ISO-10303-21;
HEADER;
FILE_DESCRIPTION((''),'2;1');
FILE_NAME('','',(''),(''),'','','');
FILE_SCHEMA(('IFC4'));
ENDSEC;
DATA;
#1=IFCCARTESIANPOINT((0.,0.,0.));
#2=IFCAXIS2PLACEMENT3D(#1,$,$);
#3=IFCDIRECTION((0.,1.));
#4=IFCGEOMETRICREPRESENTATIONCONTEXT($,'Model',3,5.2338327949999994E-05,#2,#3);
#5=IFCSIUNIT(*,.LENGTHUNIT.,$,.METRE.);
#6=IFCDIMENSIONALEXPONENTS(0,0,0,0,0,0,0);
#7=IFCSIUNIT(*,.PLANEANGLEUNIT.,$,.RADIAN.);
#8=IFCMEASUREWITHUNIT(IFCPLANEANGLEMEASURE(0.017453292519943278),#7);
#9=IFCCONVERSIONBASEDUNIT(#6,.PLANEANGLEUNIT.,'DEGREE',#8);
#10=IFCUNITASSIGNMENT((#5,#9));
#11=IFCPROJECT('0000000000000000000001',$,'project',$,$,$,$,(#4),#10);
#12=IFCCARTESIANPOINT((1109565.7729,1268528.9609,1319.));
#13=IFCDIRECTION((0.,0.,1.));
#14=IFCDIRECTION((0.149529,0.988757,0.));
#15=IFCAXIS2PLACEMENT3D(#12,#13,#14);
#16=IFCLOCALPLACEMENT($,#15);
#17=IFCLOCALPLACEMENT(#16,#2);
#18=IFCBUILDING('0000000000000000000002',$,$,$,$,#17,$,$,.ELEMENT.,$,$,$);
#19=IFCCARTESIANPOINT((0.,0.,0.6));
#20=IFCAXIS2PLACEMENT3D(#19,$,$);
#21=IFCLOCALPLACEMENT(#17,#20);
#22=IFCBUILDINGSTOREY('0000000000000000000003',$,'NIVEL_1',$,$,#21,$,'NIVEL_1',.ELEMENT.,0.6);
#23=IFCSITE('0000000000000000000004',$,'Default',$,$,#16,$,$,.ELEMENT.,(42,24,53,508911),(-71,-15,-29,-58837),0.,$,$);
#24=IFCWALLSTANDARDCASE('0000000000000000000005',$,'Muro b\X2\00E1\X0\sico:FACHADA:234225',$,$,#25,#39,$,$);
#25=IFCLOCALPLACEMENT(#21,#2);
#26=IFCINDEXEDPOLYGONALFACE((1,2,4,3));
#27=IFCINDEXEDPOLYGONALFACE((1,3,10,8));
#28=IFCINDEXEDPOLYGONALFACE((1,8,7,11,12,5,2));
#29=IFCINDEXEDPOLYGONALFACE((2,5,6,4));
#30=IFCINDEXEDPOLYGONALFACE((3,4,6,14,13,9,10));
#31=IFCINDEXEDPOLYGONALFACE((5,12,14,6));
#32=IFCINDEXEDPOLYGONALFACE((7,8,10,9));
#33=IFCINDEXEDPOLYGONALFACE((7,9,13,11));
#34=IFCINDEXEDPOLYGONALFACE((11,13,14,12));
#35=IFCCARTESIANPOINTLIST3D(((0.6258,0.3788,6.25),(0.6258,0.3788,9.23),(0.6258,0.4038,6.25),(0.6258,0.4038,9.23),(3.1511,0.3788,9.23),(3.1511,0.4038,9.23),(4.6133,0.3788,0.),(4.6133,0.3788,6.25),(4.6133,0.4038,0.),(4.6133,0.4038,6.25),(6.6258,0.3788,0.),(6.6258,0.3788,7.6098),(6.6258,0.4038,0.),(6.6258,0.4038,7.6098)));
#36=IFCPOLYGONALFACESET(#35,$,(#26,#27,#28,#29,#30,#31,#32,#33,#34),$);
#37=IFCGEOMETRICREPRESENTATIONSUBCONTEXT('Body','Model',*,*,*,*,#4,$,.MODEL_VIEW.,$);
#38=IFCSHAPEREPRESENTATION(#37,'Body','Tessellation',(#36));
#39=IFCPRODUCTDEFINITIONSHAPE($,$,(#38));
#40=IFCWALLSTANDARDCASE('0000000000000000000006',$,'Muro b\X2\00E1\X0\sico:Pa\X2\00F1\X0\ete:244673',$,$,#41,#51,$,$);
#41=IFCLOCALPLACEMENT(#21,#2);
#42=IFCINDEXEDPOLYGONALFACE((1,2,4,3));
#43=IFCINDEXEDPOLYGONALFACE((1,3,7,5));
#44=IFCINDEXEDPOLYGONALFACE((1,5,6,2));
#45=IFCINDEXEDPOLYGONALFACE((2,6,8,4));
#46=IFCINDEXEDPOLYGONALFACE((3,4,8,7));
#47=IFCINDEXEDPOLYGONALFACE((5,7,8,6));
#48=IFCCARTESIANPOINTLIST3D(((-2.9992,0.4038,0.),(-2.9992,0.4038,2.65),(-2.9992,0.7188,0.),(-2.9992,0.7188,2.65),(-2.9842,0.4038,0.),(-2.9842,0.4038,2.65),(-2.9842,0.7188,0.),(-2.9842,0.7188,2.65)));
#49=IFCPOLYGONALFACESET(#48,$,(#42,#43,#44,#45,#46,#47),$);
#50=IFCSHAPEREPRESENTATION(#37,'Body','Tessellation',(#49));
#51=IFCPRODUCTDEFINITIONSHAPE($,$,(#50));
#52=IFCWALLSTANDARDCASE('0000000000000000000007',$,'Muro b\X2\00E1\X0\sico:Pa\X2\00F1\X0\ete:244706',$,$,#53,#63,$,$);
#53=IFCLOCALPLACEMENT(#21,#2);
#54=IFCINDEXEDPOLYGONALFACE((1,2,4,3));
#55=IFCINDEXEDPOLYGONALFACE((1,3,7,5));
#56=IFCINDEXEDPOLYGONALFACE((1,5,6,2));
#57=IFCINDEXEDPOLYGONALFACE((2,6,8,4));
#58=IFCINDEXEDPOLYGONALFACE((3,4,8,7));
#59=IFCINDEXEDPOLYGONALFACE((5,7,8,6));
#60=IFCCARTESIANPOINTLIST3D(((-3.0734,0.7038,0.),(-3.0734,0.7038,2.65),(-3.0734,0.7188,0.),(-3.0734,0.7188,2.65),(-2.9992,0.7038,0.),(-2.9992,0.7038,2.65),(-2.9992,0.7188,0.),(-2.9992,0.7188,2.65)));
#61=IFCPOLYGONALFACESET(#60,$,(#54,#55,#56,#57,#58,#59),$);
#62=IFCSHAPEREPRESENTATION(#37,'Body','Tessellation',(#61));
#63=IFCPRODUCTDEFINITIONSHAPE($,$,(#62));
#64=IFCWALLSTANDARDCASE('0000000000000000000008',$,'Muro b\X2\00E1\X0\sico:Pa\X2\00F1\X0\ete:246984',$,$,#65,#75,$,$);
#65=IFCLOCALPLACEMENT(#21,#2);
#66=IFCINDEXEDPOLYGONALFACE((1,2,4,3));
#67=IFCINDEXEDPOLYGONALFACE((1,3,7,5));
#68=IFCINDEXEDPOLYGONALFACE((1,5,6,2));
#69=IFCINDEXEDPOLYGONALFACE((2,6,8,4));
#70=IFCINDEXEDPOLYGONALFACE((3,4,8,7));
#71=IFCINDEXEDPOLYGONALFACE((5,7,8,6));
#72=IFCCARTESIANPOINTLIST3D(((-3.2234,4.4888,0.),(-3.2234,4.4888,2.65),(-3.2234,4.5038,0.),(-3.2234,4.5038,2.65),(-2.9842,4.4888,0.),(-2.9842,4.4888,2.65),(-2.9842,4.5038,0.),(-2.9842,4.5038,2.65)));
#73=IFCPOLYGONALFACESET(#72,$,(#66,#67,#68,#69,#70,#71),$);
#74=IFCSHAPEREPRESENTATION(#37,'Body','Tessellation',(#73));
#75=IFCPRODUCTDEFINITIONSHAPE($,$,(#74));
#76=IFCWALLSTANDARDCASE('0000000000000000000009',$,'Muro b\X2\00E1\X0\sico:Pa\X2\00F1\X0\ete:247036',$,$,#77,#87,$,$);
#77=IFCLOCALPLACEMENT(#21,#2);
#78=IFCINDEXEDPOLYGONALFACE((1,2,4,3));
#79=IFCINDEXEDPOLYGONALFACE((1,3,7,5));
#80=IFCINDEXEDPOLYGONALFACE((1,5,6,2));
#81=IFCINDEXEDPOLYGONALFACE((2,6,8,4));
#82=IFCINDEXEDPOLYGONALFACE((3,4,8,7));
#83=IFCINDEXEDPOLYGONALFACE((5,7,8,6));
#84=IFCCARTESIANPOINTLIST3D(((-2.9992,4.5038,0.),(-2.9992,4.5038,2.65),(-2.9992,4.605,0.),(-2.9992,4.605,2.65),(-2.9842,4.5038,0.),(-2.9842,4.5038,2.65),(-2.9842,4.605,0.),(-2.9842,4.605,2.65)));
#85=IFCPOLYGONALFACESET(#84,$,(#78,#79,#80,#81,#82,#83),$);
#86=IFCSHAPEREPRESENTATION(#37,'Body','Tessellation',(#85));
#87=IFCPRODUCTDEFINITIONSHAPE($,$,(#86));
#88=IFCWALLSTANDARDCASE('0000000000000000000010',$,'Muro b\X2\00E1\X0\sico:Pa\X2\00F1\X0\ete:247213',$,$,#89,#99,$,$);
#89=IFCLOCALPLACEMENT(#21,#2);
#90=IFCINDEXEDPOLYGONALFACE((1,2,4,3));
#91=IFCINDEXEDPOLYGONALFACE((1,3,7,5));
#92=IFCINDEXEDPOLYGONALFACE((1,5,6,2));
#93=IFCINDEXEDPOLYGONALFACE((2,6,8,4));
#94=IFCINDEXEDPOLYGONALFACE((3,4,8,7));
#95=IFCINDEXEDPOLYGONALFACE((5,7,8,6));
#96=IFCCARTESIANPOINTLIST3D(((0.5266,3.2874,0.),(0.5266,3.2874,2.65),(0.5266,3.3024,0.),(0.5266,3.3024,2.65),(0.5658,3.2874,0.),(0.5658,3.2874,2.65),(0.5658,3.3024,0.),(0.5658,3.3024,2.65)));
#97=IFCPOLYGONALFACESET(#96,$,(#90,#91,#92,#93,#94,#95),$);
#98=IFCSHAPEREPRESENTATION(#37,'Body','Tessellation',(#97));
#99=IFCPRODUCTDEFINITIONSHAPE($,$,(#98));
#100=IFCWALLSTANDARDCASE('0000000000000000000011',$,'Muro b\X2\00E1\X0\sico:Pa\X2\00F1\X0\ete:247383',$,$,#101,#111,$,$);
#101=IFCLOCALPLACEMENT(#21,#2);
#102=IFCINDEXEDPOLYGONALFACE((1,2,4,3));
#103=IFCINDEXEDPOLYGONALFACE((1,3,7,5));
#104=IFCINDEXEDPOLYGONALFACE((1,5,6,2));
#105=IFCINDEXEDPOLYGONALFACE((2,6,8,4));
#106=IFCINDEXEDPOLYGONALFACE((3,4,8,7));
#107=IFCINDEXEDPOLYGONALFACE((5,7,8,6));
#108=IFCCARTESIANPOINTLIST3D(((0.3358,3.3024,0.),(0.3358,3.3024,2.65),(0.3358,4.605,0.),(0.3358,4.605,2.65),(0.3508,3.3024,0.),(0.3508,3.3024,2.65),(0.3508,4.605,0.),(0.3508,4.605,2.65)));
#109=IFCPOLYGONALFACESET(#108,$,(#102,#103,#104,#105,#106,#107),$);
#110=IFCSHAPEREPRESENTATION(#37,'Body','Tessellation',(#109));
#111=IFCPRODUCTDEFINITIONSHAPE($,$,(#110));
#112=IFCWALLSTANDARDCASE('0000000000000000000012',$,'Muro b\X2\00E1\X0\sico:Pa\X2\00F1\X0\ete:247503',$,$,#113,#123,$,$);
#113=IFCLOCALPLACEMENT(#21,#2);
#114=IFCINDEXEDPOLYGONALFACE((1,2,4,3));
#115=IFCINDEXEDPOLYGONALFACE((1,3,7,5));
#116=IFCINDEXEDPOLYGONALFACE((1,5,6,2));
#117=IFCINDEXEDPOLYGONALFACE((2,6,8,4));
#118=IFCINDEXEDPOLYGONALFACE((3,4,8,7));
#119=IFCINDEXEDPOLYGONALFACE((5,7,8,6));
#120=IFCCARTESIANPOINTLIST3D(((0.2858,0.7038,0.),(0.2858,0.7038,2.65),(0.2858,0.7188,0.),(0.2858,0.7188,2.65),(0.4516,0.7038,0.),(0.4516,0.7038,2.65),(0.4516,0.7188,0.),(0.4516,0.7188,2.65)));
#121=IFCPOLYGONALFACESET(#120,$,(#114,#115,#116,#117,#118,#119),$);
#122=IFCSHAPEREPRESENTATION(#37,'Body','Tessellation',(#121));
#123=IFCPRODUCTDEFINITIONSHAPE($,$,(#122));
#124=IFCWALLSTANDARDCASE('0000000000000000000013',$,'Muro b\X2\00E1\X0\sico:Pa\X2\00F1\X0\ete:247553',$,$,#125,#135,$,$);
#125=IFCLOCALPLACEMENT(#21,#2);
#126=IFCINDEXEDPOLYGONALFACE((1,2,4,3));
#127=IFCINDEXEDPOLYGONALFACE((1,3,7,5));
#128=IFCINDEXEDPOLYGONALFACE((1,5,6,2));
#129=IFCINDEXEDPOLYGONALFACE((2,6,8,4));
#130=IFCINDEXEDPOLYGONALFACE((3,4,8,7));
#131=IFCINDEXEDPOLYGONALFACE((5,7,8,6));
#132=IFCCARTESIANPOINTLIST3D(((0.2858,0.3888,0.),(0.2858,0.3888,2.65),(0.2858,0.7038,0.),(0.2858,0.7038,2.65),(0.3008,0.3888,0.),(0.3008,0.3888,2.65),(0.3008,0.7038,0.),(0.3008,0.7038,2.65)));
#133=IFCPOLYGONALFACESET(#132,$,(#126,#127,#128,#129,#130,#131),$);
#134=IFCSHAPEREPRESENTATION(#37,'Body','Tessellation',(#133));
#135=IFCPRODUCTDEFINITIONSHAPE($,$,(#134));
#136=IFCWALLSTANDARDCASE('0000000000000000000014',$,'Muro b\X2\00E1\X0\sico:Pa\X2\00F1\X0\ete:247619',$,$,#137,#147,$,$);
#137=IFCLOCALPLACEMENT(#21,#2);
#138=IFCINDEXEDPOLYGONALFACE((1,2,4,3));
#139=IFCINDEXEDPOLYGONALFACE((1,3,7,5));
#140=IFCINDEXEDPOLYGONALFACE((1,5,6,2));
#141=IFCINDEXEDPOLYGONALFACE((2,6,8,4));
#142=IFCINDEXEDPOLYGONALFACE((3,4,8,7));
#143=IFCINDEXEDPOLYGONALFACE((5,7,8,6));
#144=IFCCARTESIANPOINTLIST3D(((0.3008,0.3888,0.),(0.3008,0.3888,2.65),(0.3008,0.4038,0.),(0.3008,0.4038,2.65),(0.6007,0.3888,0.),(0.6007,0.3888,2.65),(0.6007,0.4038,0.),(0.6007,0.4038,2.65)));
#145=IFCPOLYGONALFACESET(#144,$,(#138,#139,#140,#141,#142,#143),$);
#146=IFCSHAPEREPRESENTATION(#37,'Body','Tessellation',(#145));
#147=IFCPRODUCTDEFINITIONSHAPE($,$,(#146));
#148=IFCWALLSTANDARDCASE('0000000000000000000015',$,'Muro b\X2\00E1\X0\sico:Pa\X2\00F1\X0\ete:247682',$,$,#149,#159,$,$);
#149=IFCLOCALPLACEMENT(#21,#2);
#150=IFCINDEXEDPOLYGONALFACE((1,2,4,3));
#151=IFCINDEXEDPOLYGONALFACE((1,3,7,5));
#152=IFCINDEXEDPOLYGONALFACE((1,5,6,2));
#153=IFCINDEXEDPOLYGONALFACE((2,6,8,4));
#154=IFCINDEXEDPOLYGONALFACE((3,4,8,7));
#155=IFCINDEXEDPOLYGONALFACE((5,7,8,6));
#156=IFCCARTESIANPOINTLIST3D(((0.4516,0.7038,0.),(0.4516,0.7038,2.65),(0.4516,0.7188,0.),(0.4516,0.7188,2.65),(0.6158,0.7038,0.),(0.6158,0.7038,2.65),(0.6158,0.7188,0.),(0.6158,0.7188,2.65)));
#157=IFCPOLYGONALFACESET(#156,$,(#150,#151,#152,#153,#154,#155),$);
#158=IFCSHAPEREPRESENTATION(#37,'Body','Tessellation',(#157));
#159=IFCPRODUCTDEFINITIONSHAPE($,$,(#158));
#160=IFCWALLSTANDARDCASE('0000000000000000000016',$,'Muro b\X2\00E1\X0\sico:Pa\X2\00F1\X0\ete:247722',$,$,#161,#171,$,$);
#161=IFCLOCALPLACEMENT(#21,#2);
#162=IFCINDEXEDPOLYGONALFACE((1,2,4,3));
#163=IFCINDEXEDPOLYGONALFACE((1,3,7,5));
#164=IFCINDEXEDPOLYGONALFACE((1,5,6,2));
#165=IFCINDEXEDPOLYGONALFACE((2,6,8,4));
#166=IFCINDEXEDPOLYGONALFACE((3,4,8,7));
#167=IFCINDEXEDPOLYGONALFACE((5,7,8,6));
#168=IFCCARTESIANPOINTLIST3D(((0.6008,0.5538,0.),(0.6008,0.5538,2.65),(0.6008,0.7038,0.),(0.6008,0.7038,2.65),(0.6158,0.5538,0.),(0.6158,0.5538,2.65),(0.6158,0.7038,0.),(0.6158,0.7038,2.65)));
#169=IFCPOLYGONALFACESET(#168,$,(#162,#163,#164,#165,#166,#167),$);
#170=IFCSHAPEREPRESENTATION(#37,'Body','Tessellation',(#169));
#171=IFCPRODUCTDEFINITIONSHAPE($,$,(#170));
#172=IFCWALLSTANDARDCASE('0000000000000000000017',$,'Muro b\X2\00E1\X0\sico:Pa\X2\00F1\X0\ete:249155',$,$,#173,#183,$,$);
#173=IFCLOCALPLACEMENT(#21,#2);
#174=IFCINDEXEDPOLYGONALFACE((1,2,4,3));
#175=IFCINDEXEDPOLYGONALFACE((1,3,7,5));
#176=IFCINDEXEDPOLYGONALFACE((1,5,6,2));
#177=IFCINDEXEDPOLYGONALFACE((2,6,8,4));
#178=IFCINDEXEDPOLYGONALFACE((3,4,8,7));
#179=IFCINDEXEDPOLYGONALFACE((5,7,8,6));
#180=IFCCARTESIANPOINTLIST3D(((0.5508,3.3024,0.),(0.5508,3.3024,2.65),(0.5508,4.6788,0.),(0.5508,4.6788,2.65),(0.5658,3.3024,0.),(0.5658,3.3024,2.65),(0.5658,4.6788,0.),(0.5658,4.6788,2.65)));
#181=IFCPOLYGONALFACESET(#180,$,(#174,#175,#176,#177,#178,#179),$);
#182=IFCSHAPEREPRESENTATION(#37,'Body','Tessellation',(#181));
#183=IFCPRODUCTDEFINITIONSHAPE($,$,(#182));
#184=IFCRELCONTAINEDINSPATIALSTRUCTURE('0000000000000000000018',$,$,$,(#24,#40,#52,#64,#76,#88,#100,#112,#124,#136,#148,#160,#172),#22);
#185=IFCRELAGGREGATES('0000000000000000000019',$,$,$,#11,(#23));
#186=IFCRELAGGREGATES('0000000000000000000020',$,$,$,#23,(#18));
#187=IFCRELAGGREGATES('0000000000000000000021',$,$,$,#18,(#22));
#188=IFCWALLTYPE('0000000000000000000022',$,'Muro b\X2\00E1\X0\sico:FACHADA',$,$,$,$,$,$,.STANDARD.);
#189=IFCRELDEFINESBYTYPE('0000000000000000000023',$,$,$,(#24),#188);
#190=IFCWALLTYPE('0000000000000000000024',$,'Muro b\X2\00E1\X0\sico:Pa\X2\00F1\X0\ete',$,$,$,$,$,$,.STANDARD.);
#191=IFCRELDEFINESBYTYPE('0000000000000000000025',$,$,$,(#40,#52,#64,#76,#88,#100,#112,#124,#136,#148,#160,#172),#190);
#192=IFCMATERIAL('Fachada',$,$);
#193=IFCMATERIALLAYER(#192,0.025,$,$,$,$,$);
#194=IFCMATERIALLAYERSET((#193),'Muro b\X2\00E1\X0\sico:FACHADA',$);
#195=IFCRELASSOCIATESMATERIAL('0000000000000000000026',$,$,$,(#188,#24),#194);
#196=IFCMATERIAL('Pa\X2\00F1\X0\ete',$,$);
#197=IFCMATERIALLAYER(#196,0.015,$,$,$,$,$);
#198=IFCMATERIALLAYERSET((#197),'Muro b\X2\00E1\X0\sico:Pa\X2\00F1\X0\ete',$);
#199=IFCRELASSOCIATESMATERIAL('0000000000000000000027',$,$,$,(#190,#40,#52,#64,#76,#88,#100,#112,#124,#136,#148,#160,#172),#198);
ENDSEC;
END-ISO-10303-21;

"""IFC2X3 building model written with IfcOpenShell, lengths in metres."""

from ifc_helpers import new_model, entity, si_unit, converted_unit, direction, frame, frame_2d, origin, origin_2d_with_axis, place, context, subcontext, project, spatial, rectangle, extrude, clip, halfspace, material, layer, layer_set, layer_usage, type_object, element, save


model = new_model("IFC2X3")

# Units and contexts
model_context = context("Model", 3, precision=5.2338327949999994e-05, world=origin(), true_north=direction((0.0, 1.0)))
body_context = subcontext(model_context, "Body", "Model", "MODEL_VIEW")
ifc_project = project(units=[si_unit("LENGTHUNIT", "METRE"), converted_unit("PLANEANGLEUNIT", "DEGREE", entity("IfcPlaneAngleMeasure", 0.017453292519943278), si_unit("PLANEANGLEUNIT", "RADIAN"), dimensions=[0, 0, 0, 0, 0, 0, 0])], contexts=[model_context])

# Site, building, storey
site_placement = place(None, frame((1109565.7729, 1268528.9609, 1319.0), z_axis=(0.0, 0.0, 1.0), x_axis=(0.149529, 0.988757, 0.0)))
site = spatial("IfcSite", under=ifc_project, at=site_placement, Name="Default", CompositionType="ELEMENT", RefLatitude=(42, 24, 53, 508911), RefLongitude=(-71, -15, -29, -58837), RefElevation=0.0)
building_placement = place(site_placement, origin())
building = spatial("IfcBuilding", under=site, at=building_placement, CompositionType="ELEMENT")
storey_placement = place(building_placement, frame((0.0, 0.0, 0.6)))
storey = spatial("IfcBuildingStorey", under=building, at=storey_placement, Name="NIVEL_1", LongName="NIVEL_1", CompositionType="ELEMENT", Elevation=0.6)

# Shared definitions
ifc_material_1 = material(Name="Pañete")

# Wall, opening
ifc_material_2 = material(Name="Fachada")
ifc_layer_1 = layer(ifc_material_2, 0.025)
ifc_layer_set_1 = layer_set([ifc_layer_1], Name="Muro básico:FACHADA")
ifc_layer_usage_1 = layer_usage(ifc_layer_set_1, "AXIS2", "POSITIVE", -0.0125)
wall_type_1 = type_object("IfcWallType", Name="Muro básico:FACHADA", PredefinedType="STANDARD", material=ifc_layer_set_1)
wall_1_placement = place(storey_placement, frame((0.6258, 0.3913, 0.0)))
wall_1 = element("IfcWallStandardCase", 1, at=wall_1_placement, inside=storey, type_object=wall_type_1, material=ifc_layer_usage_1, Name="Muro básico:FACHADA:234225", context=body_context, shape_type="Clipping", body=[
    clip(extrude(rectangle(XDim=6.0, YDim=0.025, at=frame_2d((3.0, 0.0), x_axis=(-1.0, 0.0))), origin(), (0.0, 0.0, 1.0), 9.23), halfspace(frame((2.5254, -0.0125, 9.23), z_axis=(0.422613, 0.0, 0.90631), x_axis=(0.0, 1.0, 0.0)), False)),
])
opening_1_placement = place(wall_1_placement, origin())
element("IfcOpeningElement", 2, at=opening_1_placement, cuts=wall_1, ObjectType="Opening", context=body_context, shape_type="SweptSolid", body=[
    extrude(rectangle(XDim=6.25, YDim=3.9875, at=origin_2d_with_axis()), frame((1.9938, 0.0125, 3.125), z_axis=(0.0, -1.0, 0.0), x_axis=(0.0, 0.0, -1.0)), (0.0, 0.0, 1.0), 0.025),
])

# Walls
ifc_layer_2 = layer(ifc_material_1, 0.015)
ifc_layer_set_2 = layer_set([ifc_layer_2], Name="Muro básico:Pañete")
ifc_layer_usage_2 = layer_usage(ifc_layer_set_2, "AXIS2", "POSITIVE", -0.0075)
wall_type_2 = type_object("IfcWallType", Name="Muro básico:Pañete", PredefinedType="STANDARD", material=ifc_layer_set_2)
wall_2_placement = place(storey_placement, frame((-2.9917, 0.4038, 0.0), z_axis=(0.0, 0.0, 1.0), x_axis=(0.0, 1.0, 0.0)))
element("IfcWallStandardCase", 3, at=wall_2_placement, inside=storey, type_object=wall_type_2, material=ifc_layer_usage_2, Name="Muro básico:Pañete:244673", context=body_context, shape_type="SweptSolid", body=[
    extrude(rectangle(XDim=0.315, YDim=0.015, at=frame_2d((0.1575, 0.0), x_axis=(-1.0, 0.0))), origin(), (0.0, 0.0, 1.0), 2.65),
])
ifc_layer_usage_3 = layer_usage(ifc_layer_set_2, "AXIS2", "POSITIVE", -0.0075)
wall_3_placement = place(storey_placement, frame((-2.9992, 0.7113, 0.0), z_axis=(0.0, 0.0, 1.0), x_axis=(-1.0, 0.0, 0.0)))
element("IfcWallStandardCase", 4, at=wall_3_placement, inside=storey, type_object=wall_type_2, material=ifc_layer_usage_3, Name="Muro básico:Pañete:244706", context=body_context, shape_type="SweptSolid", body=[
    extrude(rectangle(XDim=0.0741, YDim=0.015, at=frame_2d((0.0371, 0.0), x_axis=(-1.0, 0.0))), origin(), (0.0, 0.0, 1.0), 2.65),
])
ifc_layer_usage_4 = layer_usage(ifc_layer_set_2, "AXIS2", "POSITIVE", -0.0075)
wall_4_placement = place(storey_placement, frame((-3.2234, 4.4963, 0.0)))
element("IfcWallStandardCase", 5, at=wall_4_placement, inside=storey, type_object=wall_type_2, material=ifc_layer_usage_4, Name="Muro básico:Pañete:246984", context=body_context, shape_type="SweptSolid", body=[
    extrude(rectangle(XDim=0.2391, YDim=0.015, at=frame_2d((0.1196, 0.0), x_axis=(-1.0, 0.0))), origin(), (0.0, 0.0, 1.0), 2.65),
])
ifc_layer_usage_5 = layer_usage(ifc_layer_set_2, "AXIS2", "POSITIVE", -0.0075)
wall_5_placement = place(storey_placement, frame((-2.9917, 4.5038, 0.0), z_axis=(0.0, 0.0, 1.0), x_axis=(0.0, 1.0, 0.0)))
element("IfcWallStandardCase", 6, at=wall_5_placement, inside=storey, type_object=wall_type_2, material=ifc_layer_usage_5, Name="Muro básico:Pañete:247036", context=body_context, shape_type="SweptSolid", body=[
    extrude(rectangle(XDim=0.1012, YDim=0.015, at=frame_2d((0.0506, 0.0), x_axis=(-1.0, 0.0))), origin(), (0.0, 0.0, 1.0), 2.65),
])
ifc_layer_usage_6 = layer_usage(ifc_layer_set_2, "AXIS2", "NEGATIVE", 0.0075)
wall_6_placement = place(storey_placement, frame((0.5658, 3.2949, 0.0), z_axis=(0.0, 0.0, 1.0), x_axis=(-1.0, 0.0, 0.0)))
element("IfcWallStandardCase", 7, at=wall_6_placement, inside=storey, type_object=wall_type_2, material=ifc_layer_usage_6, Name="Muro básico:Pañete:247213", context=body_context, shape_type="SweptSolid", body=[
    extrude(rectangle(XDim=0.0391, YDim=0.015, at=frame_2d((0.0196, 0.0), x_axis=(-1.0, 0.0))), origin(), (0.0, 0.0, 1.0), 2.65),
])
ifc_layer_usage_7 = layer_usage(ifc_layer_set_2, "AXIS2", "NEGATIVE", 0.0075)
wall_7_placement = place(storey_placement, frame((0.3433, 3.3024, 0.0), z_axis=(0.0, 0.0, 1.0), x_axis=(0.0, 1.0, 0.0)))
element("IfcWallStandardCase", 8, at=wall_7_placement, inside=storey, type_object=wall_type_2, material=ifc_layer_usage_7, Name="Muro básico:Pañete:247383", context=body_context, shape_type="SweptSolid", body=[
    extrude(rectangle(XDim=1.3026, YDim=0.015, at=frame_2d((0.6513, 0.0), x_axis=(-1.0, 0.0))), origin(), (0.0, 0.0, 1.0), 2.65),
])
ifc_layer_usage_8 = layer_usage(ifc_layer_set_2, "AXIS2", "POSITIVE", -0.0075)
wall_8_placement = place(storey_placement, frame((0.4516, 0.7113, 0.0), z_axis=(0.0, 0.0, 1.0), x_axis=(-1.0, 0.0, 0.0)))
element("IfcWallStandardCase", 9, at=wall_8_placement, inside=storey, type_object=wall_type_2, material=ifc_layer_usage_8, Name="Muro básico:Pañete:247503", context=body_context, shape_type="SweptSolid", body=[
    extrude(rectangle(XDim=0.1659, YDim=0.015, at=frame_2d((0.0829, 0.0), x_axis=(-1.0, 0.0))), origin(), (0.0, 0.0, 1.0), 2.65),
])
ifc_layer_usage_9 = layer_usage(ifc_layer_set_2, "AXIS2", "POSITIVE", -0.0075)
wall_9_placement = place(storey_placement, frame((0.2933, 0.7038, 0.0), z_axis=(0.0, 0.0, 1.0), x_axis=(0.0, -1.0, 0.0)))
element("IfcWallStandardCase", 10, at=wall_9_placement, inside=storey, type_object=wall_type_2, material=ifc_layer_usage_9, Name="Muro básico:Pañete:247553", context=body_context, shape_type="SweptSolid", body=[
    extrude(rectangle(XDim=0.315, YDim=0.015, at=frame_2d((0.1575, 0.0), x_axis=(-1.0, 0.0))), origin(), (0.0, 0.0, 1.0), 2.65),
])
ifc_layer_usage_10 = layer_usage(ifc_layer_set_2, "AXIS2", "POSITIVE", -0.0075)
wall_10_placement = place(storey_placement, frame((0.3008, 0.3963, 0.0)))
element("IfcWallStandardCase", 11, at=wall_10_placement, inside=storey, type_object=wall_type_2, material=ifc_layer_usage_10, Name="Muro básico:Pañete:247619", context=body_context, shape_type="SweptSolid", body=[
    extrude(rectangle(XDim=0.3, YDim=0.015, at=frame_2d((0.15, 0.0), x_axis=(-1.0, 0.0))), origin(), (0.0, 0.0, 1.0), 2.65),
])
ifc_layer_usage_11 = layer_usage(ifc_layer_set_2, "AXIS2", "NEGATIVE", 0.0075)
wall_11_placement = place(storey_placement, frame((0.4516, 0.7113, 0.0)))
element("IfcWallStandardCase", 12, at=wall_11_placement, inside=storey, type_object=wall_type_2, material=ifc_layer_usage_11, Name="Muro básico:Pañete:247682", context=body_context, shape_type="SweptSolid", body=[
    extrude(rectangle(XDim=0.1641, YDim=0.015, at=frame_2d((0.0821, 0.0), x_axis=(-1.0, 0.0))), origin(), (0.0, 0.0, 1.0), 2.65),
])
ifc_layer_usage_12 = layer_usage(ifc_layer_set_2, "AXIS2", "NEGATIVE", 0.0075)
wall_12_placement = place(storey_placement, frame((0.6083, 0.7038, 0.0), z_axis=(0.0, 0.0, 1.0), x_axis=(0.0, -1.0, 0.0)))
element("IfcWallStandardCase", 13, at=wall_12_placement, inside=storey, type_object=wall_type_2, material=ifc_layer_usage_12, Name="Muro básico:Pañete:247722", context=body_context, shape_type="SweptSolid", body=[
    extrude(rectangle(XDim=0.15, YDim=0.015, at=frame_2d((0.075, 0.0), x_axis=(-1.0, 0.0))), origin(), (0.0, 0.0, 1.0), 2.65),
])
ifc_layer_usage_13 = layer_usage(ifc_layer_set_2, "AXIS2", "NEGATIVE", 0.0075)
wall_13_placement = place(storey_placement, frame((0.5583, 4.6788, 0.0), z_axis=(0.0, 0.0, 1.0), x_axis=(0.0, -1.0, 0.0)))
element("IfcWallStandardCase", 14, at=wall_13_placement, inside=storey, type_object=wall_type_2, material=ifc_layer_usage_13, Name="Muro básico:Pañete:249155", context=body_context, shape_type="SweptSolid", body=[
    extrude(rectangle(XDim=1.3764, YDim=0.015, at=frame_2d((0.6882, 0.0), x_axis=(-1.0, 0.0))), origin(), (0.0, 0.0, 1.0), 2.65),
])

save(model, "model.ifc")
